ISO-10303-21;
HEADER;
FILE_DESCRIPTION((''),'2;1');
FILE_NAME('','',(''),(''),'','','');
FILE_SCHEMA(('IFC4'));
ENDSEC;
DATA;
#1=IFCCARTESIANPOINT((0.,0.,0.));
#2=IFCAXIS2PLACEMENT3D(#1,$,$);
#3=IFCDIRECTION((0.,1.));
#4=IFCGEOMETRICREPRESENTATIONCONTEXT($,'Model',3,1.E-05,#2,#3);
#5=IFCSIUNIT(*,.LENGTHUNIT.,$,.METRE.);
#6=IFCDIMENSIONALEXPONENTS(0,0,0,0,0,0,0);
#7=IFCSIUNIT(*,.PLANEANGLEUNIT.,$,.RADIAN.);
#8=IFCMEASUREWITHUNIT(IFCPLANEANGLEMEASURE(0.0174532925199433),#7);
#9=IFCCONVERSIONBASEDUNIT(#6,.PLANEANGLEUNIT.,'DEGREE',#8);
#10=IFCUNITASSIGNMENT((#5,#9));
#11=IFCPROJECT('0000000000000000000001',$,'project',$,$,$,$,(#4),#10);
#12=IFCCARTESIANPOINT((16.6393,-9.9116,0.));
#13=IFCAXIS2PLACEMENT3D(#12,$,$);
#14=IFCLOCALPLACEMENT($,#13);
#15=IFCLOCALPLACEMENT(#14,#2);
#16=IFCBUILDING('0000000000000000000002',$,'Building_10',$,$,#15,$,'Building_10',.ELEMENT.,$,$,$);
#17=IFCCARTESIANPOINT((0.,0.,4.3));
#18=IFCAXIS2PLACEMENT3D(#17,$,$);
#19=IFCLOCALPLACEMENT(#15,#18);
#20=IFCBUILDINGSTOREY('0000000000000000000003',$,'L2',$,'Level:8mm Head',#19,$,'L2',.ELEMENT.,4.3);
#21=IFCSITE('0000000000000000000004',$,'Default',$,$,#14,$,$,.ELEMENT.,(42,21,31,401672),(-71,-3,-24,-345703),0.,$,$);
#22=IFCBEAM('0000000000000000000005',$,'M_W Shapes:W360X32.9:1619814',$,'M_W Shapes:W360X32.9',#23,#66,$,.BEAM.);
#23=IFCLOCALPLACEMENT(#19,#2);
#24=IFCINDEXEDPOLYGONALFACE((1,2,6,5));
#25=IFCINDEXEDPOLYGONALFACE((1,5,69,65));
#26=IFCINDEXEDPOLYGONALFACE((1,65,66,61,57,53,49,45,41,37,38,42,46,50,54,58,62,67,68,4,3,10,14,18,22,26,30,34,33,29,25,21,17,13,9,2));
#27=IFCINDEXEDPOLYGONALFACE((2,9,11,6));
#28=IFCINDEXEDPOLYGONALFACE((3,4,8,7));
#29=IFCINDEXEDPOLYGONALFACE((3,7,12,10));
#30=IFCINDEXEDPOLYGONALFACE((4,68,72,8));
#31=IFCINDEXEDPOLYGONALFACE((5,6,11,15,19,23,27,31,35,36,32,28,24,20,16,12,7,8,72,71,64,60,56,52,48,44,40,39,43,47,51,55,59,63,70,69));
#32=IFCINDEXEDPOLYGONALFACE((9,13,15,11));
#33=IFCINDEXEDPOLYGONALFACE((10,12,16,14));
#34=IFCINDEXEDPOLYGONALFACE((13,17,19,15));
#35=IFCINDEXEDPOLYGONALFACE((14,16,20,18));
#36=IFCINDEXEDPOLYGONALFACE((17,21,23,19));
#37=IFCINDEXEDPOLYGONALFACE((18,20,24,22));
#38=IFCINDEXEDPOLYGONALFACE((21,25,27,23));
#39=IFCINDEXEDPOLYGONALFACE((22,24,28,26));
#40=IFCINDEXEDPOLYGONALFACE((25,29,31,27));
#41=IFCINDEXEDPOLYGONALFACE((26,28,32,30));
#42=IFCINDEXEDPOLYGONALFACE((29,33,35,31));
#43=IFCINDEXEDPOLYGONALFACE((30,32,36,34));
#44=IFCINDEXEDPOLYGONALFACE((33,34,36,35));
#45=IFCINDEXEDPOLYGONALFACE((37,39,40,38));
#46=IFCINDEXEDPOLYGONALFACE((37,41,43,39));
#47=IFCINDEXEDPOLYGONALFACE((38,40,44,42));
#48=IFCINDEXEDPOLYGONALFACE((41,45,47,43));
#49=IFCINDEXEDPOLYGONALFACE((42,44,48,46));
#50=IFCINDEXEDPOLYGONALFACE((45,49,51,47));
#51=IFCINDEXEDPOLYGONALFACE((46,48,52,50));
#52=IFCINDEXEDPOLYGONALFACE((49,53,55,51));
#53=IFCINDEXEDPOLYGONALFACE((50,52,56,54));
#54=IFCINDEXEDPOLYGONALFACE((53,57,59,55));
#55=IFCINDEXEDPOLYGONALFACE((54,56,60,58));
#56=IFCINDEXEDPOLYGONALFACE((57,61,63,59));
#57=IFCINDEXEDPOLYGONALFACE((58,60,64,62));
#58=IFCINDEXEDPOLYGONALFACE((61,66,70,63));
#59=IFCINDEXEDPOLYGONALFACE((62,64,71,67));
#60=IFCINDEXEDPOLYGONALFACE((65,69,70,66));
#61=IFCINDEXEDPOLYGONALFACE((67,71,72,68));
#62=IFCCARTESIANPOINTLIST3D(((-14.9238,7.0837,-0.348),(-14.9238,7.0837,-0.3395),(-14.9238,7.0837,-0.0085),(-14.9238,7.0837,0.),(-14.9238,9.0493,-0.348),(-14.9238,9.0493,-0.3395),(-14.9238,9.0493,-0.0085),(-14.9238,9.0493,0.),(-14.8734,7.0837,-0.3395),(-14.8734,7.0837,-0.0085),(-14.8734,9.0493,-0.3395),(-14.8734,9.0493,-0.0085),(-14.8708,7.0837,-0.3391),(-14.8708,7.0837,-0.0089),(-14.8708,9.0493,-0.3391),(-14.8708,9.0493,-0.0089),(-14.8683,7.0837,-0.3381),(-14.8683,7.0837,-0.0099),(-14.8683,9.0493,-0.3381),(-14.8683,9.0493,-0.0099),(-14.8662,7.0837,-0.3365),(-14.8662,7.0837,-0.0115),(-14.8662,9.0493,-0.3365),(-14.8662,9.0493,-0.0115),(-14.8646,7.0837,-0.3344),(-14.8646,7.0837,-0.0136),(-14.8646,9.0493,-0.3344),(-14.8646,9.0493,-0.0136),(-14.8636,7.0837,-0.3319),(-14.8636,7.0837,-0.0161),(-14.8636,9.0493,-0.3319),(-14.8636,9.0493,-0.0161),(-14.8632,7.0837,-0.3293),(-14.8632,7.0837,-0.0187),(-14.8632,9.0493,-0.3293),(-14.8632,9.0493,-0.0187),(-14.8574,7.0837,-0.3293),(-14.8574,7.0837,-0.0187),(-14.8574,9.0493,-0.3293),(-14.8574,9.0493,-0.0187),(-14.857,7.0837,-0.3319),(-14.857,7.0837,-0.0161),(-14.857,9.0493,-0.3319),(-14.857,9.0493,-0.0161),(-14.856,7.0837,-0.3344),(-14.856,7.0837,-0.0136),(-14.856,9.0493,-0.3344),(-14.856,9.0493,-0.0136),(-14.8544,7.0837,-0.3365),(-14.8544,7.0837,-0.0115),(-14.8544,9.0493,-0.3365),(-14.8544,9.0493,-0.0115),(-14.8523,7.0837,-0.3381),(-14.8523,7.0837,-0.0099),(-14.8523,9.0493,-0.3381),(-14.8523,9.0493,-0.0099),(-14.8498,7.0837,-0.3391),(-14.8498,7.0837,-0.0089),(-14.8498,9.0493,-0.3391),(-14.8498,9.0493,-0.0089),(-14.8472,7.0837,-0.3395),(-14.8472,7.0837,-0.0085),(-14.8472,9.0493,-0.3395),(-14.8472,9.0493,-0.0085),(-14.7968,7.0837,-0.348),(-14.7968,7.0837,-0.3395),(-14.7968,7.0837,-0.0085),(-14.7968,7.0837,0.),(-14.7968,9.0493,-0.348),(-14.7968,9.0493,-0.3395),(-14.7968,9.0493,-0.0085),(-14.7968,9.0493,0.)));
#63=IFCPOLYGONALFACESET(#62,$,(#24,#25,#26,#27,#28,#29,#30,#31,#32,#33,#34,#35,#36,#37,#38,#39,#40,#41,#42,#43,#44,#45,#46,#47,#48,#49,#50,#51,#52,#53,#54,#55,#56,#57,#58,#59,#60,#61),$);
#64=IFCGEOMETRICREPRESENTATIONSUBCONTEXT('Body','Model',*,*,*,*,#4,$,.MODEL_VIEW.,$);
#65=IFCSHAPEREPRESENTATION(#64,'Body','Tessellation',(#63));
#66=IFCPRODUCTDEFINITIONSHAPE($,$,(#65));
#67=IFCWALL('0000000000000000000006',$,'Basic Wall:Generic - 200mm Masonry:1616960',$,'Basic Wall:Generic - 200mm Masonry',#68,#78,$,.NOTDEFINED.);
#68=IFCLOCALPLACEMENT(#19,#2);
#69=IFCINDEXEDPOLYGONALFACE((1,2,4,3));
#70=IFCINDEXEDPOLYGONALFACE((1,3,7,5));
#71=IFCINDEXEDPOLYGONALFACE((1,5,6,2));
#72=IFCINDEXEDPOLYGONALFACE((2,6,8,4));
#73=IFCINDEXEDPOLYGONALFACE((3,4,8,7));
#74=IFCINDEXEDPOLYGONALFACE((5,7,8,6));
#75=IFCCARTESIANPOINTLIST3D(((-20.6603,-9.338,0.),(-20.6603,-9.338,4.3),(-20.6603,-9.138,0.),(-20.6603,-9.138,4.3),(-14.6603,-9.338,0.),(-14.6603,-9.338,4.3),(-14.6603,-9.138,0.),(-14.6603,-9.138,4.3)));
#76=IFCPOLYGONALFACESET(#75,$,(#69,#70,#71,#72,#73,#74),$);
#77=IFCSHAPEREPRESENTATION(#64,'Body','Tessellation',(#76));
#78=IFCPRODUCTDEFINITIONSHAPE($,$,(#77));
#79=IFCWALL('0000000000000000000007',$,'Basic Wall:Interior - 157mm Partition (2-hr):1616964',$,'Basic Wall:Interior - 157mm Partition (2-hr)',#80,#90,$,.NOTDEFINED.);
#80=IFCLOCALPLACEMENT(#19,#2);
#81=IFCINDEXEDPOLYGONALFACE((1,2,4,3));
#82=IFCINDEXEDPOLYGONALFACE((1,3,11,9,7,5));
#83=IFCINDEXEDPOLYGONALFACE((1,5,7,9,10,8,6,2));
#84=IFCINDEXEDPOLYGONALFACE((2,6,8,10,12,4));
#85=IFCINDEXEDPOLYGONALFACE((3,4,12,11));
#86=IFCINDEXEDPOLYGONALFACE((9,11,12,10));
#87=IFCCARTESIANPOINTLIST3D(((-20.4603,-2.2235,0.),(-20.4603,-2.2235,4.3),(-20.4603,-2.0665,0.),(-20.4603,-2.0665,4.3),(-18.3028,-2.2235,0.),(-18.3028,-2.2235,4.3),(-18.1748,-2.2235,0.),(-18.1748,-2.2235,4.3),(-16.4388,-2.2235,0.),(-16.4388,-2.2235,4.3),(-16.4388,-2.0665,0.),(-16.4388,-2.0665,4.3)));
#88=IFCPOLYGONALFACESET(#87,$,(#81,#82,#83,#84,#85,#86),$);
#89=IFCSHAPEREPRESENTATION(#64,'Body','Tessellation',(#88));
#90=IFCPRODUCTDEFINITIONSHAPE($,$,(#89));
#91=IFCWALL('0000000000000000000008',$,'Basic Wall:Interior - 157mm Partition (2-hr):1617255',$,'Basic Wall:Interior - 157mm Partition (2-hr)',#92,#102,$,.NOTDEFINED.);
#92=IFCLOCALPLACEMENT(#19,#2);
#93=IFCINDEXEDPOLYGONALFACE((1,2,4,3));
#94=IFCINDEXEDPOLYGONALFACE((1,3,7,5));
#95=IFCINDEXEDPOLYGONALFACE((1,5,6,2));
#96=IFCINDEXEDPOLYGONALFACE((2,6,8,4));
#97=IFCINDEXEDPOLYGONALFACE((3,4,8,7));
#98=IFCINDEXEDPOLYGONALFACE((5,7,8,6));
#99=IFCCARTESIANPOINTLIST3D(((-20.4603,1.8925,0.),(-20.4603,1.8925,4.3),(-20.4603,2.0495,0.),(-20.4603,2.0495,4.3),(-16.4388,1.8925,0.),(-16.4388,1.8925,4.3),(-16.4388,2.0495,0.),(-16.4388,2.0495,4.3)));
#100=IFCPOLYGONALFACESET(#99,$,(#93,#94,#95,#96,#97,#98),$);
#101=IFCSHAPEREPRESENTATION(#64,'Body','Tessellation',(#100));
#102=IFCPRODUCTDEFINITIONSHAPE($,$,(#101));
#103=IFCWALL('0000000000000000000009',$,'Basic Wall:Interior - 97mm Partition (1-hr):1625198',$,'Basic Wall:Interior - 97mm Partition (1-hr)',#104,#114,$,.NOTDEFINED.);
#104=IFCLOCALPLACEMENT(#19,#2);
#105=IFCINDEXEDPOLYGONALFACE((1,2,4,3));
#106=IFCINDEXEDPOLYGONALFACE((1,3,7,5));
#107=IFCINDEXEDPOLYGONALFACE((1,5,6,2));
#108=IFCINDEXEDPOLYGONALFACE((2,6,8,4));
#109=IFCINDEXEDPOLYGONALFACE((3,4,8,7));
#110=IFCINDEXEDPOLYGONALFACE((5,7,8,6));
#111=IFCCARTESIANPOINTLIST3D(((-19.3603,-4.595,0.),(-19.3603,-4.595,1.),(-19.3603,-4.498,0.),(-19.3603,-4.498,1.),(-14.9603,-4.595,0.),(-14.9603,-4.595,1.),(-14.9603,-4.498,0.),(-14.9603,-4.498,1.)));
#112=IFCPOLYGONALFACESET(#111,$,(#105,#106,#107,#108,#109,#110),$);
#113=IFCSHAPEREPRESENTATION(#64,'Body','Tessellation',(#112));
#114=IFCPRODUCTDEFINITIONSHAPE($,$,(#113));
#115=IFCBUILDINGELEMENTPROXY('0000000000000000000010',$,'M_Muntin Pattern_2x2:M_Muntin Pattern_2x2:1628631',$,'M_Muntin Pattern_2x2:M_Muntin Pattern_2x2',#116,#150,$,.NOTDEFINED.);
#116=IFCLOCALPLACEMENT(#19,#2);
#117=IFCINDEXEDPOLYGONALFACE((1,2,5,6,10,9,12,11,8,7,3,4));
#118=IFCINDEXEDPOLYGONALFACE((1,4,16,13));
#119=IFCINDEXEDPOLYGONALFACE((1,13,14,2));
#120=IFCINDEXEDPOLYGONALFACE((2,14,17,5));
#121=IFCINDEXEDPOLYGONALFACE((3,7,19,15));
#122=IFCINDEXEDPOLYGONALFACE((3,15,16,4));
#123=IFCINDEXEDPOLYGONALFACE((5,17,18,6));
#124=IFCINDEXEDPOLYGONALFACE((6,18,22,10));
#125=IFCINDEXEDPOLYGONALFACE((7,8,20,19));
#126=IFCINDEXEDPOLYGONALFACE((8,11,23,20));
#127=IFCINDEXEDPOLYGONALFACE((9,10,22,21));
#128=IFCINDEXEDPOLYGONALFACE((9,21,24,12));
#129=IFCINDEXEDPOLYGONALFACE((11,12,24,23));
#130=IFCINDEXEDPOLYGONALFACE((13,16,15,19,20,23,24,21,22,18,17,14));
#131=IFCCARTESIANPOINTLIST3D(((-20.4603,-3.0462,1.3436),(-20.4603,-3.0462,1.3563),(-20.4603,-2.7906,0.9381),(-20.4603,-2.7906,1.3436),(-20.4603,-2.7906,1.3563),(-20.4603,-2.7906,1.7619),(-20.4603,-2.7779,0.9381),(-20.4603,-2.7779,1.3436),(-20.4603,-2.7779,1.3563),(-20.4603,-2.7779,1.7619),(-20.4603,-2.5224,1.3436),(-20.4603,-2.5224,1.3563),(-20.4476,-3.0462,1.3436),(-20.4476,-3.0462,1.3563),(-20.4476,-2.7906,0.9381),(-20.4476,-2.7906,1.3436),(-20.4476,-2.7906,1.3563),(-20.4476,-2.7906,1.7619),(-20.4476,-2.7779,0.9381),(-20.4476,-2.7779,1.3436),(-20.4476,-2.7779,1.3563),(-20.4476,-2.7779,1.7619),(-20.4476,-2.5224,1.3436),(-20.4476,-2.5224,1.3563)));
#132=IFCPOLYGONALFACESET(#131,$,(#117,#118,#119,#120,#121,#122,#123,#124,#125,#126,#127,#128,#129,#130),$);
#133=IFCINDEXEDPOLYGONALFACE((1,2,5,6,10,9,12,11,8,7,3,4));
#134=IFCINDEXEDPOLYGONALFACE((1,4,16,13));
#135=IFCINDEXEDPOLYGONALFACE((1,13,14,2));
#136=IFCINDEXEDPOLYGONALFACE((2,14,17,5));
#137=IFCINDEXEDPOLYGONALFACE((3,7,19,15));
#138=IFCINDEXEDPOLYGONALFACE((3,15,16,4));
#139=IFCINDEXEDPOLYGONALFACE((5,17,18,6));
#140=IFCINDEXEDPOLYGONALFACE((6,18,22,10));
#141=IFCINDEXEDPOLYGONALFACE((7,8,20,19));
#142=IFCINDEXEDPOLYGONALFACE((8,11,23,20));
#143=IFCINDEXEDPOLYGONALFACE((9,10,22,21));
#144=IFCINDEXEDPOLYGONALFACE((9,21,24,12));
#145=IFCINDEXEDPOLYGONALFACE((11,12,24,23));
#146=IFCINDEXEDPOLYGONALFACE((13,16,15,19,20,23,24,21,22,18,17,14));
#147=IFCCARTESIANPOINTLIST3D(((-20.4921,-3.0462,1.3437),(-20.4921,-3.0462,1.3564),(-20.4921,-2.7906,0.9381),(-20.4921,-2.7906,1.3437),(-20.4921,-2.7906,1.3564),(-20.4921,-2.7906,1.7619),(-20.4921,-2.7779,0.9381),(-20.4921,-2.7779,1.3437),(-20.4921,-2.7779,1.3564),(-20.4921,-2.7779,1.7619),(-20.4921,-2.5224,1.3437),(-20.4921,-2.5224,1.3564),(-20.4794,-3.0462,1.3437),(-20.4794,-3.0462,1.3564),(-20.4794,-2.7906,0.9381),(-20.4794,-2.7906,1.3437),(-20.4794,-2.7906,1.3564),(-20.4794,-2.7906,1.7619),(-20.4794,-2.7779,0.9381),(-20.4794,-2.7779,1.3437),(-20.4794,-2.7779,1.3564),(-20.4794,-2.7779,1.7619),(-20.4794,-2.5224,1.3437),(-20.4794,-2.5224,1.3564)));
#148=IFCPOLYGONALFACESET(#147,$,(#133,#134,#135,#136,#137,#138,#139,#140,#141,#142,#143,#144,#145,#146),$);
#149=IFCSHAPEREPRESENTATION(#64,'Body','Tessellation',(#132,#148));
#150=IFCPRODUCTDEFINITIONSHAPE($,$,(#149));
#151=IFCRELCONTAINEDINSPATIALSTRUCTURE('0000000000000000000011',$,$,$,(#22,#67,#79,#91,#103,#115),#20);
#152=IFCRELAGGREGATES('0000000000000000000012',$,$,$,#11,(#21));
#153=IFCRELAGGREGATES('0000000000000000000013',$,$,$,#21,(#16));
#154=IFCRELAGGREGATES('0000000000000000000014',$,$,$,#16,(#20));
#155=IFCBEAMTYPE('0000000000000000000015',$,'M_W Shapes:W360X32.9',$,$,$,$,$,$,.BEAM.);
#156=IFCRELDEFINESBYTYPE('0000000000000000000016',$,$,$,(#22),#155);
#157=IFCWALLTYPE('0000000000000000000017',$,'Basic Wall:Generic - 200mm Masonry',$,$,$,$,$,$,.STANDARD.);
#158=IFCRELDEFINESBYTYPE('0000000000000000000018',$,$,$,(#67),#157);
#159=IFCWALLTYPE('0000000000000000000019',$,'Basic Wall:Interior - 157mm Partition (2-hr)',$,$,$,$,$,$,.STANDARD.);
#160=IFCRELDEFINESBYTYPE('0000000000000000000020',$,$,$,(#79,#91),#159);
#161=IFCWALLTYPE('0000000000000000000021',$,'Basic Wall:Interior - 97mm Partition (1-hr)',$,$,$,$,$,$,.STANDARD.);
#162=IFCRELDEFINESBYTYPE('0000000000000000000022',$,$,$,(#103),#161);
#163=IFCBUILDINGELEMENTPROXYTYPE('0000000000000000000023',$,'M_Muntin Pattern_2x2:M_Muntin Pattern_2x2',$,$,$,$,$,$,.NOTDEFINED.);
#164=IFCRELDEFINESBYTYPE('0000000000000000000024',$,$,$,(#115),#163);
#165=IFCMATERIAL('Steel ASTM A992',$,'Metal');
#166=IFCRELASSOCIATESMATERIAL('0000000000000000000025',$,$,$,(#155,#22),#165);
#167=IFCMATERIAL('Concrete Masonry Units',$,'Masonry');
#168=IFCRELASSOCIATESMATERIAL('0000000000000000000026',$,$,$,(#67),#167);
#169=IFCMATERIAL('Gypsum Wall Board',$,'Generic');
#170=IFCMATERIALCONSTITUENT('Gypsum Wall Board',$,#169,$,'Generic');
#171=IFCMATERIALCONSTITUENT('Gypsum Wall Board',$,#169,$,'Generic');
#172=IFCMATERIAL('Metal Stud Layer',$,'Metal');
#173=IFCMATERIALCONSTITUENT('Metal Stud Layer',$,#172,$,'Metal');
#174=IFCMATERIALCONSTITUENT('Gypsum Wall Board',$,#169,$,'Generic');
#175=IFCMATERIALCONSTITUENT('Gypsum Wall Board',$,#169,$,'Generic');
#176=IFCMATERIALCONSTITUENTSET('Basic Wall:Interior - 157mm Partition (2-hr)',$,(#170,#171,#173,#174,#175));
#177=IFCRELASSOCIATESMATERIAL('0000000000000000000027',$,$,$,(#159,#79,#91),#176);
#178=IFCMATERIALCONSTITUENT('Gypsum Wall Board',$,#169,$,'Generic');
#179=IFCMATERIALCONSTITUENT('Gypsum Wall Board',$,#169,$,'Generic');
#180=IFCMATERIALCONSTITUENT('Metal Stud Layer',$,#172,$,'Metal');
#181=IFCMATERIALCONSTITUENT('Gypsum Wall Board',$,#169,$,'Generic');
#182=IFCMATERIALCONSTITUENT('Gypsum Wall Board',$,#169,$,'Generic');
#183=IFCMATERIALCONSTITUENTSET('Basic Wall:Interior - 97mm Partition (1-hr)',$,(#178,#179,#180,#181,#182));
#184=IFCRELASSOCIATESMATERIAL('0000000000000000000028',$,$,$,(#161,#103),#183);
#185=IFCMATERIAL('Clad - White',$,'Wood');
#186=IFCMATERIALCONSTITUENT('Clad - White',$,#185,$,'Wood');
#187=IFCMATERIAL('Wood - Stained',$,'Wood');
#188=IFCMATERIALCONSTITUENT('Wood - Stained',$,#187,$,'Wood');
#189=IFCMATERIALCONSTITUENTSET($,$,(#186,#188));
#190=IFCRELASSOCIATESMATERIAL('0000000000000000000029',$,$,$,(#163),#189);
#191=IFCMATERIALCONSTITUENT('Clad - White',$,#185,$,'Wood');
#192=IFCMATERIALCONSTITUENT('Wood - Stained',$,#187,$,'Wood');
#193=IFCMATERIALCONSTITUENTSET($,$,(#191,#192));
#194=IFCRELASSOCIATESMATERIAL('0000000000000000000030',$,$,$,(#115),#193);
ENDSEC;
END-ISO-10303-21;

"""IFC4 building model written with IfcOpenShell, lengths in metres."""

from ifc_helpers import new_model, entity, si_unit, converted_unit, direction, frame, origin, place, context, subcontext, project, spatial, line, arc, indexed_curve, outline, extrude, source, transform, mapped, material, constituent, constituent_set, type_object, type_shapes, element, save


model = new_model("IFC4")

# Units and contexts
model_context = context("Model", 3, precision=1e-05, world=origin(), true_north=direction((0.0, 1.0)))
body_context = subcontext(model_context, "Body", "Model", "MODEL_VIEW")
ifc_project = project(units=[si_unit("LENGTHUNIT", "METRE"), converted_unit("PLANEANGLEUNIT", "DEGREE", entity("IfcPlaneAngleMeasure", 0.0174532925199433), si_unit("PLANEANGLEUNIT", "RADIAN"), dimensions=[0, 0, 0, 0, 0, 0, 0])], contexts=[model_context])

# Site, building, storey
site_placement = place(None, frame((16.6393, -9.9116, 0.0)))
site = spatial("IfcSite", under=ifc_project, at=site_placement, Name="Default", CompositionType="ELEMENT", RefLatitude=(42, 21, 31, 401672), RefLongitude=(-71, -3, -24, -345703), RefElevation=0.0)
building_placement = place(site_placement, origin())
building = spatial("IfcBuilding", under=site, at=building_placement, Name="Building_10", LongName="Building_10", CompositionType="ELEMENT")
storey_placement = place(building_placement, frame((0.0, 0.0, 4.3)))
storey = spatial("IfcBuildingStorey", under=building, at=storey_placement, Name="L2", ObjectType="Level:8mm Head", LongName="L2", CompositionType="ELEMENT", Elevation=4.3)

# Beam
ifc_material_1 = material(Name="Steel ASTM A992", Category="Metal")
beam_type_1 = type_object("IfcBeamType", Name="M_W Shapes:W360X32.9", PredefinedType="BEAM", material=ifc_material_1)
shared_shape_1 = source(origin(), body_context, "Body", "SweptSolid", [
    extrude(outline(indexed_curve([(-0.0635, -0.1655), (-0.0635, -0.174), (0.0635, -0.174), (0.0635, -0.1655), (0.0131, -0.1655), (0.0059, -0.1625), (0.0029, -0.1553), (0.0029, 0.1553), (0.0059, 0.1625), (0.0131, 0.1655), (0.0635, 0.1655), (0.0635, 0.174), (-0.0635, 0.174), (-0.0635, 0.1655), (-0.0131, 0.1655), (-0.0059, 0.1625), (-0.0029, 0.1553), (-0.0029, -0.1553), (-0.0059, -0.1625), (-0.0131, -0.1655)], segments=[line(1, 2, 3, 4, 5), arc(5, 6, 7), line(7, 8), arc(8, 9, 10), line(10, 11, 12, 13, 14, 15), arc(15, 16, 17), line(17, 18), arc(18, 19, 20), line(20, 1)], self_intersect=False)), frame((-0.9828, 0.0, 0.0), z_axis=(-1.0, 0.0, 0.0), x_axis=(0.0, -1.0, 0.0)), (0.0, 0.0, -1.0), 1.9656),
])
type_shapes(beam_type_1, [shared_shape_1])
for number, where, z_axis, x_axis, name in (
    (1, (-14.8603, 8.0665, -0.174), (0.0, 0.0, 1.0), (0.0, 1.0, 0.0), "M_W Shapes:W360X32.9:1619814"),
):
    element("IfcBeam", number, at=place(storey_placement, frame(where, z_axis=z_axis, x_axis=x_axis)), inside=storey, type_object=beam_type_1, material=ifc_material_1, Name=name, ObjectType="M_W Shapes:W360X32.9", PredefinedType="BEAM", context=body_context, shape_type="MappedRepresentation", body=[
        mapped(shared_shape_1, transform((0.0, 0.0, 0.0), scale=1.0)),
    ])

# Walls
ifc_material_2 = material(Name="Concrete Masonry Units", Category="Masonry")
wall_type_1 = type_object("IfcWallType", Name="Basic Wall:Generic - 200mm Masonry", PredefinedType="STANDARD")
wall_1_placement = place(storey_placement, frame((-20.6603, -9.238, 0.0)))
element("IfcWall", 2, at=wall_1_placement, inside=storey, type_object=wall_type_1, material=ifc_material_2, Name="Basic Wall:Generic - 200mm Masonry:1616960", ObjectType="Basic Wall:Generic - 200mm Masonry", PredefinedType="NOTDEFINED", context=body_context, shape_type="SweptSolid", body=[
    extrude(outline(indexed_curve([(6.0, -0.1), (6.0, 0.1), (0.0, 0.1), (0.0, -0.1), (6.0, -0.1)], self_intersect=False)), origin(), (0.0, 0.0, 1.0), 4.3),
])
ifc_material_3 = material(Name="Gypsum Wall Board", Category="Generic")
ifc_material_4 = material(Name="Metal Stud Layer", Category="Metal")
ifc_constituent_1 = constituent(ifc_material_3, Name="Gypsum Wall Board", Category="Generic")
ifc_constituent_2 = constituent(ifc_material_3, Name="Gypsum Wall Board", Category="Generic")
ifc_constituent_3 = constituent(ifc_material_4, Name="Metal Stud Layer", Category="Metal")
ifc_constituent_4 = constituent(ifc_material_3, Name="Gypsum Wall Board", Category="Generic")
ifc_constituent_5 = constituent(ifc_material_3, Name="Gypsum Wall Board", Category="Generic")
ifc_constituent_set_1 = constituent_set(constituents=[ifc_constituent_1, ifc_constituent_2, ifc_constituent_3, ifc_constituent_4, ifc_constituent_5], Name="Basic Wall:Interior - 157mm Partition (2-hr)")
wall_type_2 = type_object("IfcWallType", Name="Basic Wall:Interior - 157mm Partition (2-hr)", PredefinedType="STANDARD", material=ifc_constituent_set_1)
wall_2_placement = place(storey_placement, frame((-20.4603, -2.145, 0.0)))
element("IfcWall", 3, at=wall_2_placement, inside=storey, type_object=wall_type_2, material=ifc_constituent_set_1, Name="Basic Wall:Interior - 157mm Partition (2-hr):1616964", ObjectType="Basic Wall:Interior - 157mm Partition (2-hr)", PredefinedType="NOTDEFINED", context=body_context, shape_type="SweptSolid", body=[
    extrude(outline(indexed_curve([(4.0215, -0.0785), (4.0215, 0.0785), (0.0, 0.0785), (0.0, -0.0785), (2.1575, -0.0785), (2.2855, -0.0785), (4.0215, -0.0785)], self_intersect=False)), origin(), (0.0, 0.0, 1.0), 4.3),
])
wall_3_placement = place(storey_placement, frame((-20.4603, 1.971, 0.0)))
element("IfcWall", 4, at=wall_3_placement, inside=storey, type_object=wall_type_2, material=ifc_constituent_set_1, Name="Basic Wall:Interior - 157mm Partition (2-hr):1617255", ObjectType="Basic Wall:Interior - 157mm Partition (2-hr)", PredefinedType="NOTDEFINED", context=body_context, shape_type="SweptSolid", body=[
    extrude(outline(indexed_curve([(4.0215, -0.0785), (4.0215, 0.0785), (0.0, 0.0785), (0.0, -0.0785), (4.0215, -0.0785)], self_intersect=False)), origin(), (0.0, 0.0, 1.0), 4.3),
])
ifc_constituent_6 = constituent(ifc_material_3, Name="Gypsum Wall Board", Category="Generic")
ifc_constituent_7 = constituent(ifc_material_3, Name="Gypsum Wall Board", Category="Generic")
ifc_constituent_8 = constituent(ifc_material_4, Name="Metal Stud Layer", Category="Metal")
ifc_constituent_9 = constituent(ifc_material_3, Name="Gypsum Wall Board", Category="Generic")
ifc_constituent_10 = constituent(ifc_material_3, Name="Gypsum Wall Board", Category="Generic")
ifc_constituent_set_2 = constituent_set(constituents=[ifc_constituent_6, ifc_constituent_7, ifc_constituent_8, ifc_constituent_9, ifc_constituent_10], Name="Basic Wall:Interior - 97mm Partition (1-hr)")
wall_type_3 = type_object("IfcWallType", Name="Basic Wall:Interior - 97mm Partition (1-hr)", PredefinedType="STANDARD", material=ifc_constituent_set_2)
wall_4_placement = place(storey_placement, frame((-14.9603, -4.5465, 0.0), z_axis=(0.0, 0.0, 1.0), x_axis=(-1.0, 0.0, 0.0)))
element("IfcWall", 5, at=wall_4_placement, inside=storey, type_object=wall_type_3, material=ifc_constituent_set_2, Name="Basic Wall:Interior - 97mm Partition (1-hr):1625198", ObjectType="Basic Wall:Interior - 97mm Partition (1-hr)", PredefinedType="NOTDEFINED", context=body_context, shape_type="SweptSolid", body=[
    extrude(outline(indexed_curve([(4.4, -0.0485), (4.4, 0.0485), (0.0, 0.0485), (0.0, -0.0485), (4.4, -0.0485)], self_intersect=False)), origin(), (0.0, 0.0, 1.0), 1.0),
])

# Building element proxy
ifc_material_5 = material(Name="Clad - White", Category="Wood")
ifc_constituent_11 = constituent(ifc_material_5, Name="Clad - White", Category="Wood")
ifc_material_6 = material(Name="Wood - Stained", Category="Wood")
ifc_constituent_12 = constituent(ifc_material_6, Name="Wood - Stained", Category="Wood")
ifc_constituent_set_3 = constituent_set(constituents=[ifc_constituent_11, ifc_constituent_12])
ifc_constituent_13 = constituent(ifc_material_5, Name="Clad - White", Category="Wood")
ifc_constituent_14 = constituent(ifc_material_6, Name="Wood - Stained", Category="Wood")
ifc_constituent_set_4 = constituent_set(constituents=[ifc_constituent_13, ifc_constituent_14])
building_element_proxy_type_1 = type_object("IfcBuildingElementProxyType", Name="M_Muntin Pattern_2x2:M_Muntin Pattern_2x2", PredefinedType="NOTDEFINED", material=ifc_constituent_set_4)
shared_shape_2 = source(origin(), body_context, "Body", "SweptSolid", [
    extrude(outline(indexed_curve([(0.0064, -0.0064), (0.4119, -0.0064), (0.4119, 0.0063), (0.0064, 0.0063), (0.0064, 0.2619), (-0.0063, 0.2619), (-0.0063, 0.0063), (-0.4119, 0.0063), (-0.4119, -0.0064), (-0.0063, -0.0064), (-0.0063, -0.2619), (0.0064, -0.2619), (0.0064, -0.0064)], self_intersect=False)), frame((0.0, -0.0222, 0.4119), z_axis=(0.0, 1.0, 0.0), x_axis=(0.0, 0.0, 1.0)), (0.0, 0.0, 1.0), 0.0127),
    extrude(outline(indexed_curve([(0.0064, -0.0064), (0.4119, -0.0064), (0.4119, 0.0063), (0.0064, 0.0063), (0.0064, 0.2619), (-0.0063, 0.2619), (-0.0063, 0.0063), (-0.4119, 0.0063), (-0.4119, -0.0064), (-0.0063, -0.0064), (-0.0063, -0.2619), (0.0064, -0.2619), (0.0064, -0.0064)], self_intersect=False)), frame((0.0, 0.0095, 0.4119), z_axis=(0.0, 1.0, 0.0), x_axis=(0.0, 0.0, 1.0)), (0.0, 0.0, 1.0), 0.0127),
])
type_shapes(building_element_proxy_type_1, [shared_shape_2])
proxy_1_placement = place(storey_placement, frame((-20.4698, -2.7843, 0.9381), z_axis=(0.0, 0.0, 1.0), x_axis=(0.0, 1.0, 0.0)))
element("IfcBuildingElementProxy", 6, at=proxy_1_placement, inside=storey, type_object=building_element_proxy_type_1, material=ifc_constituent_set_3, Name="M_Muntin Pattern_2x2:M_Muntin Pattern_2x2:1628631", ObjectType="M_Muntin Pattern_2x2:M_Muntin Pattern_2x2", PredefinedType="NOTDEFINED", context=body_context, shape_type="MappedRepresentation", body=[
    mapped(shared_shape_2, transform((0.0, 0.0, 0.0), scale=1.0)),
])

save(model, "model.ifc")
